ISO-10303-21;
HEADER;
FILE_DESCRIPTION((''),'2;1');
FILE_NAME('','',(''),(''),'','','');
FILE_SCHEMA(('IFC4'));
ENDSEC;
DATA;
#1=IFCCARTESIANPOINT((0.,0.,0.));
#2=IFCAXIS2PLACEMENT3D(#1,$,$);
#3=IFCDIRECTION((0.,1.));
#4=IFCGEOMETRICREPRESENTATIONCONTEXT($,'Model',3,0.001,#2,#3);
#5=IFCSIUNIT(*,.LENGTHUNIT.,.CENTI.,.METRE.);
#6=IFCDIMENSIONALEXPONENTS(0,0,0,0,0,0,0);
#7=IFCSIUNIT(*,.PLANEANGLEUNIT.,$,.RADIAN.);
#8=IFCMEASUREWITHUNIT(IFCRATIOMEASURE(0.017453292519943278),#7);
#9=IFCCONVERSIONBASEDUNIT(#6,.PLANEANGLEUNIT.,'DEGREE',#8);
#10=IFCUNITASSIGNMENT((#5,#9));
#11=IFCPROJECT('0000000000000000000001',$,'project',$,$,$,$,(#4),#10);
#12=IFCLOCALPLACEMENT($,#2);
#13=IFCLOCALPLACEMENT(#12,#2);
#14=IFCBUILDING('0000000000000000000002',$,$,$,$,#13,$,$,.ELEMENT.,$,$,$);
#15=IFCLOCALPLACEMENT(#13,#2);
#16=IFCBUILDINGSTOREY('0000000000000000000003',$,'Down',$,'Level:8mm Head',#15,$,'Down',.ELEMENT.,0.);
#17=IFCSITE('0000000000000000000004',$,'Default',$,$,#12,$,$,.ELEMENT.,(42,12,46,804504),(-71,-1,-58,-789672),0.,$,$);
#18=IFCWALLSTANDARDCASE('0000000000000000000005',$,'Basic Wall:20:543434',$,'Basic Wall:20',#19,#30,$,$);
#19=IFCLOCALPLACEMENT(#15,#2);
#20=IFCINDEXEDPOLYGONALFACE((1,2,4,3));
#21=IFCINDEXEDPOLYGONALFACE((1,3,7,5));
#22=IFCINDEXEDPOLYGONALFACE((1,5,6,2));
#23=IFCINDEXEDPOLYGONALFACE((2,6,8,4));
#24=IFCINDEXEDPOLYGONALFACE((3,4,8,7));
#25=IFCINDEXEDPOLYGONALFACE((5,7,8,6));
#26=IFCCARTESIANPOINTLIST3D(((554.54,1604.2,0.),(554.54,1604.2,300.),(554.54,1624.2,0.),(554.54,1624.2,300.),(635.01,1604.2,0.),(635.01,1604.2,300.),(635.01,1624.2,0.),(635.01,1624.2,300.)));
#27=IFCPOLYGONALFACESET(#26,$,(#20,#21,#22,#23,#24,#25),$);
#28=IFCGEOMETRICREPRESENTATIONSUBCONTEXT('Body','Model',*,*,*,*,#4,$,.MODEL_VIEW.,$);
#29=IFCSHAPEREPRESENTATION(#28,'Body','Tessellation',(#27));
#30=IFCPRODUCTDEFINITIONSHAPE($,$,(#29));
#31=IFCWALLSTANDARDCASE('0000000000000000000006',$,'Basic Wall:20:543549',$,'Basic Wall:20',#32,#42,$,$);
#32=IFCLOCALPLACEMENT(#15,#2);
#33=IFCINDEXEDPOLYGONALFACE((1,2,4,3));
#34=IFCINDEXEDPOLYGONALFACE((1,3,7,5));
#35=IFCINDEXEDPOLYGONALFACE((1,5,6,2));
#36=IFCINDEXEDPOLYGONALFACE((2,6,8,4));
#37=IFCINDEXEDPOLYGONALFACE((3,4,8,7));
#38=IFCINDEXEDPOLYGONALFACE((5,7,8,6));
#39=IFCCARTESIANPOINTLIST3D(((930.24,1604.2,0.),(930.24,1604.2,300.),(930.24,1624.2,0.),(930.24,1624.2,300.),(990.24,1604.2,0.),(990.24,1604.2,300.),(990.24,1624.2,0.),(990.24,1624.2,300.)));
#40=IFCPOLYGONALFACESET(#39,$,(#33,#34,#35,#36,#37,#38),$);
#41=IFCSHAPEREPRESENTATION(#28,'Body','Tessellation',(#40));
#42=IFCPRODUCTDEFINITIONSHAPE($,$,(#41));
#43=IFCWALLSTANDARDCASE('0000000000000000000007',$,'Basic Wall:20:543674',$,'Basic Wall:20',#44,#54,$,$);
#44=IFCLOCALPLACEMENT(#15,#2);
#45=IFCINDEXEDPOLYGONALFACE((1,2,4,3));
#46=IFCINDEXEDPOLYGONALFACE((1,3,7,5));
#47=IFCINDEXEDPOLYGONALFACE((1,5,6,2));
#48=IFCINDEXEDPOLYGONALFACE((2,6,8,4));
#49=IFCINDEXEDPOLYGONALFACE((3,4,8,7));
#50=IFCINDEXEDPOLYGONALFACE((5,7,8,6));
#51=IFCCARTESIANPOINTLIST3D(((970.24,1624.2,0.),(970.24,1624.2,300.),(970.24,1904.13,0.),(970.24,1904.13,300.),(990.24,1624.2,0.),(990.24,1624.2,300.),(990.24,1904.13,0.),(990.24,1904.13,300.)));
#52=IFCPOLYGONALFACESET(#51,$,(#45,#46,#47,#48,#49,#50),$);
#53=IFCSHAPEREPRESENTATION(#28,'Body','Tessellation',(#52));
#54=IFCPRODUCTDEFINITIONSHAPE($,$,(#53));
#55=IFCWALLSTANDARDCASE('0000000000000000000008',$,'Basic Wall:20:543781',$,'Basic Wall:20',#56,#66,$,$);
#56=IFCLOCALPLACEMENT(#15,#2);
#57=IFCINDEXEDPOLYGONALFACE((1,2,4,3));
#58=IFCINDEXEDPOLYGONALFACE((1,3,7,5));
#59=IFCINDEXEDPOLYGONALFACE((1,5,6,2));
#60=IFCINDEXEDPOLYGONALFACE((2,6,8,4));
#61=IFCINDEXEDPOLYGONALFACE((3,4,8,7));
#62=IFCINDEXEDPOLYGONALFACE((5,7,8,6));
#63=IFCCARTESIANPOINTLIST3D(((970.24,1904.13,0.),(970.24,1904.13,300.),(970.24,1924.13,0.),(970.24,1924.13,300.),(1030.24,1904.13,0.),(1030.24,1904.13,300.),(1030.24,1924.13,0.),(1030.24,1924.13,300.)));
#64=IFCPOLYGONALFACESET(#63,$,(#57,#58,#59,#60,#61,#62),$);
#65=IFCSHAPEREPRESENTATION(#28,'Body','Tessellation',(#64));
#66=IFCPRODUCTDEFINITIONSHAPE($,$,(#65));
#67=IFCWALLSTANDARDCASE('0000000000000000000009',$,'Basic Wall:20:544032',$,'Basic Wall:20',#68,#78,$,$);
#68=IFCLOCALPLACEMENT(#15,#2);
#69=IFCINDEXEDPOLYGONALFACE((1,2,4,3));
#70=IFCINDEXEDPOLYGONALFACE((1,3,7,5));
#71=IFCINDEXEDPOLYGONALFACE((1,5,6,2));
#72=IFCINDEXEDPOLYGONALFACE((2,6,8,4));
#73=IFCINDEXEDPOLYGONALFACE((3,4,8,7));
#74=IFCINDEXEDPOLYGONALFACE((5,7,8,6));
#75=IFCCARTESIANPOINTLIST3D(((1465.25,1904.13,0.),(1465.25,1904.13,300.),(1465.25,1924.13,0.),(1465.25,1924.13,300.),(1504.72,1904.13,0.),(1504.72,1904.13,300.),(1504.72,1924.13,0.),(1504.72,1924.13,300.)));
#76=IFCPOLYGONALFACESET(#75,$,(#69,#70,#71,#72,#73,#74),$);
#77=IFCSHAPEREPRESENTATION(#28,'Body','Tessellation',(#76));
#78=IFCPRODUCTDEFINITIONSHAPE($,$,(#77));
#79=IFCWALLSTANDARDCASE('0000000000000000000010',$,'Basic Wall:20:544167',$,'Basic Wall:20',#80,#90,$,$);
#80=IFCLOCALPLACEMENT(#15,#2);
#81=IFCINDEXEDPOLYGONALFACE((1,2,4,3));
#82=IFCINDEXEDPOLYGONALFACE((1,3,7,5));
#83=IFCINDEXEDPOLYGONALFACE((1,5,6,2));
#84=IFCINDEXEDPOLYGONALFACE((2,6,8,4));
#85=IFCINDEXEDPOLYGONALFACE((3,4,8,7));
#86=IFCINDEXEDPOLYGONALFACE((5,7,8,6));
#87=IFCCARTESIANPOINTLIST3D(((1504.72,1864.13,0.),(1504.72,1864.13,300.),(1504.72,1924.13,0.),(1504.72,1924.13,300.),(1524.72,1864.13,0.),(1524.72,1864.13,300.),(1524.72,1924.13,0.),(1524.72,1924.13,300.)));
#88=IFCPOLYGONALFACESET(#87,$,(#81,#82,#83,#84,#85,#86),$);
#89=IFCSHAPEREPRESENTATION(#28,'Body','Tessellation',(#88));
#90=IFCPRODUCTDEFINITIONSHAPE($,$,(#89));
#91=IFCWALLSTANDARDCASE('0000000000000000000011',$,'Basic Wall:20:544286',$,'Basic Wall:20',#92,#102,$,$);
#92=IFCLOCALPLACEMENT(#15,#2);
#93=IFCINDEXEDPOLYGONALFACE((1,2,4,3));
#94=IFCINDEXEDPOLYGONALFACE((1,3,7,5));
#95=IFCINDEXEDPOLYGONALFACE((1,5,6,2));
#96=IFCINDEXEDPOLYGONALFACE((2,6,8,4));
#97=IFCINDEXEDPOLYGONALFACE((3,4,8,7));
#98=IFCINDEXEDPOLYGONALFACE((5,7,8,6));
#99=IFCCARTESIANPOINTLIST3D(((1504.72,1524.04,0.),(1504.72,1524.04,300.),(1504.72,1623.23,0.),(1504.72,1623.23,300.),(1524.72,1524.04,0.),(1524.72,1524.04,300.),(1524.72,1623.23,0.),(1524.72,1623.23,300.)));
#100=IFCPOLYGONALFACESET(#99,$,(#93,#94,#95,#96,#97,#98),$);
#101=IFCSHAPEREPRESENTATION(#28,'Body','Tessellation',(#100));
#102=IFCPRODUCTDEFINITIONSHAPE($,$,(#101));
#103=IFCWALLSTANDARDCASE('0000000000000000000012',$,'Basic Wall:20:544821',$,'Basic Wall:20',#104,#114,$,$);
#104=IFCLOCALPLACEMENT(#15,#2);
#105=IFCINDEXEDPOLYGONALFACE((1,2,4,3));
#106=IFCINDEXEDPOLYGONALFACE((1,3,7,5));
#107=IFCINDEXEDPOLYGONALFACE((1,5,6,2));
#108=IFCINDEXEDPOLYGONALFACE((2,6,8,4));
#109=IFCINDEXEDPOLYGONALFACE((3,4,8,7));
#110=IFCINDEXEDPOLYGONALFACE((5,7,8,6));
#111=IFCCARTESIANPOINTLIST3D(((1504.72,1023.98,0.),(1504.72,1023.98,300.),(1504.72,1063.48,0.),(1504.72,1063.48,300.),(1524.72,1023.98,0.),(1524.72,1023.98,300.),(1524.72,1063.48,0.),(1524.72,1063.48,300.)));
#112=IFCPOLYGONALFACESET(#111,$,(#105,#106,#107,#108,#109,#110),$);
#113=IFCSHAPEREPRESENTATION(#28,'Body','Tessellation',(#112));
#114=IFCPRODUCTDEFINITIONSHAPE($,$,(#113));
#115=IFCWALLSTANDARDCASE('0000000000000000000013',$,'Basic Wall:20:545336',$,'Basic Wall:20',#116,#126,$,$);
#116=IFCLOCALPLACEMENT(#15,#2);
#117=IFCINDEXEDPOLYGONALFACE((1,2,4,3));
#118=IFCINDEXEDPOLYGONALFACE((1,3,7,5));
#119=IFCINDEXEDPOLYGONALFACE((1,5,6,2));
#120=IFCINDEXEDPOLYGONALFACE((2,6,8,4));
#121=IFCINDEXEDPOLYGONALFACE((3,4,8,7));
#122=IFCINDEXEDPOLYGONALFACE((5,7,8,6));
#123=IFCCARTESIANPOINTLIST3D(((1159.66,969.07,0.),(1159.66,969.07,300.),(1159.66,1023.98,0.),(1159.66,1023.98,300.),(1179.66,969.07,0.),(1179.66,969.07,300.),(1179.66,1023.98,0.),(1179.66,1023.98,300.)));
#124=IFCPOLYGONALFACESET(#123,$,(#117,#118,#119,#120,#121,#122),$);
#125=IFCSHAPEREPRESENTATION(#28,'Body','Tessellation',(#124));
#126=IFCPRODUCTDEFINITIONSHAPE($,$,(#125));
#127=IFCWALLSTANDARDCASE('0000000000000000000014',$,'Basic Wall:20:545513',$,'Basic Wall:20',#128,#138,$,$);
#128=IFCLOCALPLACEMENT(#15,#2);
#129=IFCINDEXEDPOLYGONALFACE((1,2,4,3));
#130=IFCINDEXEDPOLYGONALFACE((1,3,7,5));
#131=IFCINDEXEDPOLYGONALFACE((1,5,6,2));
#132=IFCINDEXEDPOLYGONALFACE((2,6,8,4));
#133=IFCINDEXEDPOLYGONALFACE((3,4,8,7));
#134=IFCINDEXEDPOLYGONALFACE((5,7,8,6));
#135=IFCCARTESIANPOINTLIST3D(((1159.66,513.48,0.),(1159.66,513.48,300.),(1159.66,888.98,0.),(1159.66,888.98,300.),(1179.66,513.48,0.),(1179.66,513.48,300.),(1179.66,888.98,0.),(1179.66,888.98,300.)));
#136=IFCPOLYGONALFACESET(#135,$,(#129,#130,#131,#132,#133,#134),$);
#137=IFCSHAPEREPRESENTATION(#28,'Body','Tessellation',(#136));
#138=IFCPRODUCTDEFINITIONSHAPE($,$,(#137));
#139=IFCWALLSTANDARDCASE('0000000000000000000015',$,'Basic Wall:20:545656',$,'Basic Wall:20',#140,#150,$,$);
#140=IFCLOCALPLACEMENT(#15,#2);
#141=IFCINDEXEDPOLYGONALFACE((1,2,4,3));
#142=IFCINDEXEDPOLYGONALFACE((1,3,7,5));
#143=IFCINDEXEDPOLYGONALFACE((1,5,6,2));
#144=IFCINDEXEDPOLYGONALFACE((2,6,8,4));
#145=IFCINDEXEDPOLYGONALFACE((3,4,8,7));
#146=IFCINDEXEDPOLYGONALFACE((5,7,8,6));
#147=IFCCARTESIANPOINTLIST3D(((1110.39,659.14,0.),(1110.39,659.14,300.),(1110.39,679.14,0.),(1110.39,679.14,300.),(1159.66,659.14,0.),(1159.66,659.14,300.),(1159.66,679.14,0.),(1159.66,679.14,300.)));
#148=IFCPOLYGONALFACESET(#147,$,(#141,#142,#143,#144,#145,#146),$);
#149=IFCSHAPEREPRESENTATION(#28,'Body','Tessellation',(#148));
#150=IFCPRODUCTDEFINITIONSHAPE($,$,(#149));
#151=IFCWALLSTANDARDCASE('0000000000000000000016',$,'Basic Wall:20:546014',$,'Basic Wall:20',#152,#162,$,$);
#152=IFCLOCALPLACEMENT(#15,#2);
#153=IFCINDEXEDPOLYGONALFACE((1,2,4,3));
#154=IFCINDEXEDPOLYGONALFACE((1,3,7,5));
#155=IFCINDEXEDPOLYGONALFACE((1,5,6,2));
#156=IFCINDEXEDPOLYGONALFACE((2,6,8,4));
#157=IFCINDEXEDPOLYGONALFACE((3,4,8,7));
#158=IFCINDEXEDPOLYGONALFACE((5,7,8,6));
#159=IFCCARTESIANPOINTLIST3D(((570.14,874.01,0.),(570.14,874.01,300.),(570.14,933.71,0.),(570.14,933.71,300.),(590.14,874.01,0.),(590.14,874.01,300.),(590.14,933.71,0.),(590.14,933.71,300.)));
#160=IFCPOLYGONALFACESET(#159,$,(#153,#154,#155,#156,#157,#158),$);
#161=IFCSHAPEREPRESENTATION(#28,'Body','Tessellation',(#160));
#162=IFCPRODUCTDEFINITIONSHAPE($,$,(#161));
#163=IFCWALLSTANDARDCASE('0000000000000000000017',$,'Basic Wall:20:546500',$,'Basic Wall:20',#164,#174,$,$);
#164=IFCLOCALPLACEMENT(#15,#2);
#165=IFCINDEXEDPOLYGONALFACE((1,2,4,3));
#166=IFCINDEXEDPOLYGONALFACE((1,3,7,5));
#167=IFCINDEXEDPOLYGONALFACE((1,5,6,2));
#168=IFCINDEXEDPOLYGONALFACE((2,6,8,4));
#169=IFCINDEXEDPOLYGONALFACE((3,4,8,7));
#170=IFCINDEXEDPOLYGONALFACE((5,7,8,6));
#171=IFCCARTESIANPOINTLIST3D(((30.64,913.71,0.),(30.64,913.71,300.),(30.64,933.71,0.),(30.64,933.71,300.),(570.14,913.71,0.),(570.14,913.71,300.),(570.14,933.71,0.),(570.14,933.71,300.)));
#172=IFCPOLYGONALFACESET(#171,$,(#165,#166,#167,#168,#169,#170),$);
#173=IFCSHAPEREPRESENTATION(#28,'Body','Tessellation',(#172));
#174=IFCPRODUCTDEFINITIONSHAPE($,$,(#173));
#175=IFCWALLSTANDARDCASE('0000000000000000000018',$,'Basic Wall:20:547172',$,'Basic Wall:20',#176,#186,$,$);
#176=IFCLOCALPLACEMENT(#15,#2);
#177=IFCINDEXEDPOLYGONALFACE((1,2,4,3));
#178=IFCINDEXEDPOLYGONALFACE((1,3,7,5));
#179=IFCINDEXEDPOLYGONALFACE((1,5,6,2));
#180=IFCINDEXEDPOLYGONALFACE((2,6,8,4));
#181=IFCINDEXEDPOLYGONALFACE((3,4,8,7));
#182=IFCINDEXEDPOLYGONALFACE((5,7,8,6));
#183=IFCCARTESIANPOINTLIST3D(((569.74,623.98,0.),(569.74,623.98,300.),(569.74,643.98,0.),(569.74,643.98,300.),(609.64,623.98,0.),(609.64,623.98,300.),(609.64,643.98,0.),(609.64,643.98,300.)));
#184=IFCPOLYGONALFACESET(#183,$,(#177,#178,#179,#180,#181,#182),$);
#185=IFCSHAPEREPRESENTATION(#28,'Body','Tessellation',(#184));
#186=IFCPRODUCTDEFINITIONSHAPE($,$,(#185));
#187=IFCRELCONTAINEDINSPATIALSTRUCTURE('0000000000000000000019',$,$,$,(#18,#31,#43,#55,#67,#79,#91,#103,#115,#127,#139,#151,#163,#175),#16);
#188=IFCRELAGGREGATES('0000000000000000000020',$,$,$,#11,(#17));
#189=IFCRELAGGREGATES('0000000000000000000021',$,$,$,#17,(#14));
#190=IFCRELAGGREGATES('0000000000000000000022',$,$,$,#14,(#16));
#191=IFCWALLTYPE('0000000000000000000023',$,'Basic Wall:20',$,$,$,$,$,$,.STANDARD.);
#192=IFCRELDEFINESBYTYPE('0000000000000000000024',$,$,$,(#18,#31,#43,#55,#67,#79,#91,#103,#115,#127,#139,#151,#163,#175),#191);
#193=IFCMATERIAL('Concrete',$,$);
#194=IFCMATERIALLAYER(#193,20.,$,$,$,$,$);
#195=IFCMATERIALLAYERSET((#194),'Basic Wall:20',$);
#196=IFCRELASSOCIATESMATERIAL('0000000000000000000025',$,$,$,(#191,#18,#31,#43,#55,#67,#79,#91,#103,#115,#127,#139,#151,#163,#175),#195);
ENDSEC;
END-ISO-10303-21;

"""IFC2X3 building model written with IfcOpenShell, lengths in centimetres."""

from ifc_helpers import new_model, entity, si_unit, converted_unit, direction, frame, frame_2d, origin, place, context, subcontext, project, spatial, rectangle, extrude, material, layer, layer_set, layer_usage, type_object, element, save


model = new_model("IFC2X3")

# Units and contexts
model_context = context("Model", 3, precision=0.001, world=origin(), true_north=direction((0.0, 1.0)))
body_context = subcontext(model_context, "Body", "Model", "MODEL_VIEW")
ifc_project = project(units=[si_unit("LENGTHUNIT", "METRE", prefix="CENTI"), converted_unit("PLANEANGLEUNIT", "DEGREE", entity("IfcRatioMeasure", 0.017453292519943278), si_unit("PLANEANGLEUNIT", "RADIAN"), dimensions=[0, 0, 0, 0, 0, 0, 0])], contexts=[model_context])

# Site, building, storey
site_placement = place(None, origin())
site = spatial("IfcSite", under=ifc_project, at=site_placement, Name="Default", CompositionType="ELEMENT", RefLatitude=(42, 12, 46, 804504), RefLongitude=(-71, -1, -58, -789672), RefElevation=0.0)
building_placement = place(site_placement, origin())
building = spatial("IfcBuilding", under=site, at=building_placement, CompositionType="ELEMENT")
storey_placement = place(building_placement, origin())
storey = spatial("IfcBuildingStorey", under=building, at=storey_placement, Name="Down", ObjectType="Level:8mm Head", LongName="Down", CompositionType="ELEMENT", Elevation=0.0)

# Walls
ifc_material = material(Name="Concrete")
ifc_layer_1 = layer(ifc_material, 20.0)
ifc_layer_set_1 = layer_set([ifc_layer_1], Name="Basic Wall:20")
ifc_layer_usage_1 = layer_usage(ifc_layer_set_1, "AXIS2", "NEGATIVE", 10.0)
wall_type_1 = type_object("IfcWallType", Name="Basic Wall:20", PredefinedType="STANDARD", material=ifc_layer_set_1)
wall_1_placement = place(storey_placement, frame((554.54, 1614.2, 0.0)))
element("IfcWallStandardCase", 1, at=wall_1_placement, inside=storey, type_object=wall_type_1, material=ifc_layer_usage_1, Name="Basic Wall:20:543434", ObjectType="Basic Wall:20", context=body_context, shape_type="SweptSolid", body=[
    extrude(rectangle(XDim=80.47, YDim=20.0, at=frame_2d((40.23, 0.0), x_axis=(-1.0, 0.0))), origin(), (0.0, 0.0, 1.0), 300.0),
])
ifc_layer_usage_2 = layer_usage(ifc_layer_set_1, "AXIS2", "POSITIVE", -10.0)
wall_2_placement = place(storey_placement, frame((930.24, 1614.2, 0.0)))
element("IfcWallStandardCase", 2, at=wall_2_placement, inside=storey, type_object=wall_type_1, material=ifc_layer_usage_2, Name="Basic Wall:20:543549", ObjectType="Basic Wall:20", context=body_context, shape_type="SweptSolid", body=[
    extrude(rectangle(XDim=60.0, YDim=20.0, at=frame_2d((30.0, 0.0), x_axis=(-1.0, 0.0))), origin(), (0.0, 0.0, 1.0), 300.0),
])
ifc_layer_usage_3 = layer_usage(ifc_layer_set_1, "AXIS2", "POSITIVE", -10.0)
wall_3_placement = place(storey_placement, frame((980.24, 1624.2, 0.0), z_axis=(0.0, 0.0, 1.0), x_axis=(0.0, 1.0, 0.0)))
element("IfcWallStandardCase", 3, at=wall_3_placement, inside=storey, type_object=wall_type_1, material=ifc_layer_usage_3, Name="Basic Wall:20:543674", ObjectType="Basic Wall:20", context=body_context, shape_type="SweptSolid", body=[
    extrude(rectangle(XDim=279.94, YDim=20.0, at=frame_2d((139.97, 0.0), x_axis=(-1.0, 0.0))), origin(), (0.0, 0.0, 1.0), 300.0),
])
ifc_layer_usage_4 = layer_usage(ifc_layer_set_1, "AXIS2", "NEGATIVE", 10.0)
wall_4_placement = place(storey_placement, frame((970.24, 1914.13, 0.0)))
element("IfcWallStandardCase", 4, at=wall_4_placement, inside=storey, type_object=wall_type_1, material=ifc_layer_usage_4, Name="Basic Wall:20:543781", ObjectType="Basic Wall:20", context=body_context, shape_type="SweptSolid", body=[
    extrude(rectangle(XDim=60.0, YDim=20.0, at=frame_2d((30.0, 0.0), x_axis=(-1.0, 0.0))), origin(), (0.0, 0.0, 1.0), 300.0),
])
ifc_layer_usage_5 = layer_usage(ifc_layer_set_1, "AXIS2", "POSITIVE", -10.0)
wall_5_placement = place(storey_placement, frame((1465.25, 1914.13, 0.0)))
element("IfcWallStandardCase", 5, at=wall_5_placement, inside=storey, type_object=wall_type_1, material=ifc_layer_usage_5, Name="Basic Wall:20:544032", ObjectType="Basic Wall:20", context=body_context, shape_type="SweptSolid", body=[
    extrude(rectangle(XDim=39.47, YDim=20.0, at=frame_2d((19.73, 0.0), x_axis=(-1.0, 0.0))), origin(), (0.0, 0.0, 1.0), 300.0),
])
ifc_layer_usage_6 = layer_usage(ifc_layer_set_1, "AXIS2", "NEGATIVE", 10.0)
wall_6_placement = place(storey_placement, frame((1514.72, 1924.13, 0.0), z_axis=(0.0, 0.0, 1.0), x_axis=(0.0, -1.0, 0.0)))
element("IfcWallStandardCase", 6, at=wall_6_placement, inside=storey, type_object=wall_type_1, material=ifc_layer_usage_6, Name="Basic Wall:20:544167", ObjectType="Basic Wall:20", context=body_context, shape_type="SweptSolid", body=[
    extrude(rectangle(XDim=60.0, YDim=20.0, at=frame_2d((30.0, 0.0), x_axis=(-1.0, 0.0))), origin(), (0.0, 0.0, 1.0), 300.0),
])
ifc_layer_usage_7 = layer_usage(ifc_layer_set_1, "AXIS2", "NEGATIVE", 10.0)
wall_7_placement = place(storey_placement, frame((1514.72, 1623.23, 0.0), z_axis=(0.0, 0.0, 1.0), x_axis=(0.0, -1.0, 0.0)))
element("IfcWallStandardCase", 7, at=wall_7_placement, inside=storey, type_object=wall_type_1, material=ifc_layer_usage_7, Name="Basic Wall:20:544286", ObjectType="Basic Wall:20", context=body_context, shape_type="SweptSolid", body=[
    extrude(rectangle(XDim=99.19, YDim=20.0, at=frame_2d((49.59, 0.0), x_axis=(-1.0, 0.0))), origin(), (0.0, 0.0, 1.0), 300.0),
])
ifc_layer_usage_8 = layer_usage(ifc_layer_set_1, "AXIS2", "NEGATIVE", 10.0)
wall_8_placement = place(storey_placement, frame((1514.72, 1063.48, 0.0), z_axis=(0.0, 0.0, 1.0), x_axis=(0.0, -1.0, 0.0)))
element("IfcWallStandardCase", 8, at=wall_8_placement, inside=storey, type_object=wall_type_1, material=ifc_layer_usage_8, Name="Basic Wall:20:544821", ObjectType="Basic Wall:20", context=body_context, shape_type="SweptSolid", body=[
    extrude(rectangle(XDim=39.5, YDim=20.0, at=frame_2d((19.75, 0.0), x_axis=(-1.0, 0.0))), origin(), (0.0, 0.0, 1.0), 300.0),
])
ifc_layer_usage_9 = layer_usage(ifc_layer_set_1, "AXIS2", "POSITIVE", -10.0)
wall_9_placement = place(storey_placement, frame((1169.66, 1023.98, 0.0), z_axis=(0.0, 0.0, 1.0), x_axis=(0.0, -1.0, 0.0)))
element("IfcWallStandardCase", 9, at=wall_9_placement, inside=storey, type_object=wall_type_1, material=ifc_layer_usage_9, Name="Basic Wall:20:545336", ObjectType="Basic Wall:20", context=body_context, shape_type="SweptSolid", body=[
    extrude(rectangle(XDim=54.91, YDim=20.0, at=frame_2d((27.46, 0.0), x_axis=(-1.0, 0.0))), origin(), (0.0, 0.0, 1.0), 300.0),
])
ifc_layer_usage_10 = layer_usage(ifc_layer_set_1, "AXIS2", "POSITIVE", -10.0)
wall_10_placement = place(storey_placement, frame((1169.66, 888.98, 0.0), z_axis=(0.0, 0.0, 1.0), x_axis=(0.0, -1.0, 0.0)))
element("IfcWallStandardCase", 10, at=wall_10_placement, inside=storey, type_object=wall_type_1, material=ifc_layer_usage_10, Name="Basic Wall:20:545513", ObjectType="Basic Wall:20", context=body_context, shape_type="SweptSolid", body=[
    extrude(rectangle(XDim=375.5, YDim=20.0, at=frame_2d((187.75, 0.0), x_axis=(-1.0, 0.0))), origin(), (0.0, 0.0, 1.0), 300.0),
])
ifc_layer_usage_11 = layer_usage(ifc_layer_set_1, "AXIS2", "POSITIVE", -10.0)
wall_11_placement = place(storey_placement, frame((1110.39, 669.14, 0.0)))
element("IfcWallStandardCase", 11, at=wall_11_placement, inside=storey, type_object=wall_type_1, material=ifc_layer_usage_11, Name="Basic Wall:20:545656", ObjectType="Basic Wall:20", context=body_context, shape_type="SweptSolid", body=[
    extrude(rectangle(XDim=49.27, YDim=20.0, at=frame_2d((24.63, 0.0), x_axis=(-1.0, 0.0))), origin(), (0.0, 0.0, 1.0), 300.0),
])
ifc_layer_usage_12 = layer_usage(ifc_layer_set_1, "AXIS2", "NEGATIVE", 10.0)
wall_12_placement = place(storey_placement, frame((580.14, 933.71, 0.0), z_axis=(0.0, 0.0, 1.0), x_axis=(0.0, -1.0, 0.0)))
element("IfcWallStandardCase", 12, at=wall_12_placement, inside=storey, type_object=wall_type_1, material=ifc_layer_usage_12, Name="Basic Wall:20:546014", ObjectType="Basic Wall:20", context=body_context, shape_type="SweptSolid", body=[
    extrude(rectangle(XDim=59.7, YDim=20.0, at=frame_2d((29.85, 0.0), x_axis=(-1.0, 0.0))), origin(), (0.0, 0.0, 1.0), 300.0),
])
ifc_layer_usage_13 = layer_usage(ifc_layer_set_1, "AXIS2", "NEGATIVE", 10.0)
wall_13_placement = place(storey_placement, frame((570.14, 923.71, 0.0), z_axis=(0.0, 0.0, 1.0), x_axis=(-1.0, 0.0, 0.0)))
element("IfcWallStandardCase", 13, at=wall_13_placement, inside=storey, type_object=wall_type_1, material=ifc_layer_usage_13, Name="Basic Wall:20:546500", ObjectType="Basic Wall:20", context=body_context, shape_type="SweptSolid", body=[
    extrude(rectangle(XDim=539.5, YDim=20.0, at=frame_2d((269.75, 0.0), x_axis=(-1.0, 0.0))), origin(), (0.0, 0.0, 1.0), 300.0),
])
ifc_layer_usage_14 = layer_usage(ifc_layer_set_1, "AXIS2", "POSITIVE", -10.0)
wall_14_placement = place(storey_placement, frame((569.74, 633.98, 0.0)))
element("IfcWallStandardCase", 14, at=wall_14_placement, inside=storey, type_object=wall_type_1, material=ifc_layer_usage_14, Name="Basic Wall:20:547172", ObjectType="Basic Wall:20", context=body_context, shape_type="SweptSolid", body=[
    extrude(rectangle(XDim=39.9, YDim=20.0, at=frame_2d((19.95, 0.0), x_axis=(-1.0, 0.0))), origin(), (0.0, 0.0, 1.0), 300.0),
])

save(model, "model.ifc")
